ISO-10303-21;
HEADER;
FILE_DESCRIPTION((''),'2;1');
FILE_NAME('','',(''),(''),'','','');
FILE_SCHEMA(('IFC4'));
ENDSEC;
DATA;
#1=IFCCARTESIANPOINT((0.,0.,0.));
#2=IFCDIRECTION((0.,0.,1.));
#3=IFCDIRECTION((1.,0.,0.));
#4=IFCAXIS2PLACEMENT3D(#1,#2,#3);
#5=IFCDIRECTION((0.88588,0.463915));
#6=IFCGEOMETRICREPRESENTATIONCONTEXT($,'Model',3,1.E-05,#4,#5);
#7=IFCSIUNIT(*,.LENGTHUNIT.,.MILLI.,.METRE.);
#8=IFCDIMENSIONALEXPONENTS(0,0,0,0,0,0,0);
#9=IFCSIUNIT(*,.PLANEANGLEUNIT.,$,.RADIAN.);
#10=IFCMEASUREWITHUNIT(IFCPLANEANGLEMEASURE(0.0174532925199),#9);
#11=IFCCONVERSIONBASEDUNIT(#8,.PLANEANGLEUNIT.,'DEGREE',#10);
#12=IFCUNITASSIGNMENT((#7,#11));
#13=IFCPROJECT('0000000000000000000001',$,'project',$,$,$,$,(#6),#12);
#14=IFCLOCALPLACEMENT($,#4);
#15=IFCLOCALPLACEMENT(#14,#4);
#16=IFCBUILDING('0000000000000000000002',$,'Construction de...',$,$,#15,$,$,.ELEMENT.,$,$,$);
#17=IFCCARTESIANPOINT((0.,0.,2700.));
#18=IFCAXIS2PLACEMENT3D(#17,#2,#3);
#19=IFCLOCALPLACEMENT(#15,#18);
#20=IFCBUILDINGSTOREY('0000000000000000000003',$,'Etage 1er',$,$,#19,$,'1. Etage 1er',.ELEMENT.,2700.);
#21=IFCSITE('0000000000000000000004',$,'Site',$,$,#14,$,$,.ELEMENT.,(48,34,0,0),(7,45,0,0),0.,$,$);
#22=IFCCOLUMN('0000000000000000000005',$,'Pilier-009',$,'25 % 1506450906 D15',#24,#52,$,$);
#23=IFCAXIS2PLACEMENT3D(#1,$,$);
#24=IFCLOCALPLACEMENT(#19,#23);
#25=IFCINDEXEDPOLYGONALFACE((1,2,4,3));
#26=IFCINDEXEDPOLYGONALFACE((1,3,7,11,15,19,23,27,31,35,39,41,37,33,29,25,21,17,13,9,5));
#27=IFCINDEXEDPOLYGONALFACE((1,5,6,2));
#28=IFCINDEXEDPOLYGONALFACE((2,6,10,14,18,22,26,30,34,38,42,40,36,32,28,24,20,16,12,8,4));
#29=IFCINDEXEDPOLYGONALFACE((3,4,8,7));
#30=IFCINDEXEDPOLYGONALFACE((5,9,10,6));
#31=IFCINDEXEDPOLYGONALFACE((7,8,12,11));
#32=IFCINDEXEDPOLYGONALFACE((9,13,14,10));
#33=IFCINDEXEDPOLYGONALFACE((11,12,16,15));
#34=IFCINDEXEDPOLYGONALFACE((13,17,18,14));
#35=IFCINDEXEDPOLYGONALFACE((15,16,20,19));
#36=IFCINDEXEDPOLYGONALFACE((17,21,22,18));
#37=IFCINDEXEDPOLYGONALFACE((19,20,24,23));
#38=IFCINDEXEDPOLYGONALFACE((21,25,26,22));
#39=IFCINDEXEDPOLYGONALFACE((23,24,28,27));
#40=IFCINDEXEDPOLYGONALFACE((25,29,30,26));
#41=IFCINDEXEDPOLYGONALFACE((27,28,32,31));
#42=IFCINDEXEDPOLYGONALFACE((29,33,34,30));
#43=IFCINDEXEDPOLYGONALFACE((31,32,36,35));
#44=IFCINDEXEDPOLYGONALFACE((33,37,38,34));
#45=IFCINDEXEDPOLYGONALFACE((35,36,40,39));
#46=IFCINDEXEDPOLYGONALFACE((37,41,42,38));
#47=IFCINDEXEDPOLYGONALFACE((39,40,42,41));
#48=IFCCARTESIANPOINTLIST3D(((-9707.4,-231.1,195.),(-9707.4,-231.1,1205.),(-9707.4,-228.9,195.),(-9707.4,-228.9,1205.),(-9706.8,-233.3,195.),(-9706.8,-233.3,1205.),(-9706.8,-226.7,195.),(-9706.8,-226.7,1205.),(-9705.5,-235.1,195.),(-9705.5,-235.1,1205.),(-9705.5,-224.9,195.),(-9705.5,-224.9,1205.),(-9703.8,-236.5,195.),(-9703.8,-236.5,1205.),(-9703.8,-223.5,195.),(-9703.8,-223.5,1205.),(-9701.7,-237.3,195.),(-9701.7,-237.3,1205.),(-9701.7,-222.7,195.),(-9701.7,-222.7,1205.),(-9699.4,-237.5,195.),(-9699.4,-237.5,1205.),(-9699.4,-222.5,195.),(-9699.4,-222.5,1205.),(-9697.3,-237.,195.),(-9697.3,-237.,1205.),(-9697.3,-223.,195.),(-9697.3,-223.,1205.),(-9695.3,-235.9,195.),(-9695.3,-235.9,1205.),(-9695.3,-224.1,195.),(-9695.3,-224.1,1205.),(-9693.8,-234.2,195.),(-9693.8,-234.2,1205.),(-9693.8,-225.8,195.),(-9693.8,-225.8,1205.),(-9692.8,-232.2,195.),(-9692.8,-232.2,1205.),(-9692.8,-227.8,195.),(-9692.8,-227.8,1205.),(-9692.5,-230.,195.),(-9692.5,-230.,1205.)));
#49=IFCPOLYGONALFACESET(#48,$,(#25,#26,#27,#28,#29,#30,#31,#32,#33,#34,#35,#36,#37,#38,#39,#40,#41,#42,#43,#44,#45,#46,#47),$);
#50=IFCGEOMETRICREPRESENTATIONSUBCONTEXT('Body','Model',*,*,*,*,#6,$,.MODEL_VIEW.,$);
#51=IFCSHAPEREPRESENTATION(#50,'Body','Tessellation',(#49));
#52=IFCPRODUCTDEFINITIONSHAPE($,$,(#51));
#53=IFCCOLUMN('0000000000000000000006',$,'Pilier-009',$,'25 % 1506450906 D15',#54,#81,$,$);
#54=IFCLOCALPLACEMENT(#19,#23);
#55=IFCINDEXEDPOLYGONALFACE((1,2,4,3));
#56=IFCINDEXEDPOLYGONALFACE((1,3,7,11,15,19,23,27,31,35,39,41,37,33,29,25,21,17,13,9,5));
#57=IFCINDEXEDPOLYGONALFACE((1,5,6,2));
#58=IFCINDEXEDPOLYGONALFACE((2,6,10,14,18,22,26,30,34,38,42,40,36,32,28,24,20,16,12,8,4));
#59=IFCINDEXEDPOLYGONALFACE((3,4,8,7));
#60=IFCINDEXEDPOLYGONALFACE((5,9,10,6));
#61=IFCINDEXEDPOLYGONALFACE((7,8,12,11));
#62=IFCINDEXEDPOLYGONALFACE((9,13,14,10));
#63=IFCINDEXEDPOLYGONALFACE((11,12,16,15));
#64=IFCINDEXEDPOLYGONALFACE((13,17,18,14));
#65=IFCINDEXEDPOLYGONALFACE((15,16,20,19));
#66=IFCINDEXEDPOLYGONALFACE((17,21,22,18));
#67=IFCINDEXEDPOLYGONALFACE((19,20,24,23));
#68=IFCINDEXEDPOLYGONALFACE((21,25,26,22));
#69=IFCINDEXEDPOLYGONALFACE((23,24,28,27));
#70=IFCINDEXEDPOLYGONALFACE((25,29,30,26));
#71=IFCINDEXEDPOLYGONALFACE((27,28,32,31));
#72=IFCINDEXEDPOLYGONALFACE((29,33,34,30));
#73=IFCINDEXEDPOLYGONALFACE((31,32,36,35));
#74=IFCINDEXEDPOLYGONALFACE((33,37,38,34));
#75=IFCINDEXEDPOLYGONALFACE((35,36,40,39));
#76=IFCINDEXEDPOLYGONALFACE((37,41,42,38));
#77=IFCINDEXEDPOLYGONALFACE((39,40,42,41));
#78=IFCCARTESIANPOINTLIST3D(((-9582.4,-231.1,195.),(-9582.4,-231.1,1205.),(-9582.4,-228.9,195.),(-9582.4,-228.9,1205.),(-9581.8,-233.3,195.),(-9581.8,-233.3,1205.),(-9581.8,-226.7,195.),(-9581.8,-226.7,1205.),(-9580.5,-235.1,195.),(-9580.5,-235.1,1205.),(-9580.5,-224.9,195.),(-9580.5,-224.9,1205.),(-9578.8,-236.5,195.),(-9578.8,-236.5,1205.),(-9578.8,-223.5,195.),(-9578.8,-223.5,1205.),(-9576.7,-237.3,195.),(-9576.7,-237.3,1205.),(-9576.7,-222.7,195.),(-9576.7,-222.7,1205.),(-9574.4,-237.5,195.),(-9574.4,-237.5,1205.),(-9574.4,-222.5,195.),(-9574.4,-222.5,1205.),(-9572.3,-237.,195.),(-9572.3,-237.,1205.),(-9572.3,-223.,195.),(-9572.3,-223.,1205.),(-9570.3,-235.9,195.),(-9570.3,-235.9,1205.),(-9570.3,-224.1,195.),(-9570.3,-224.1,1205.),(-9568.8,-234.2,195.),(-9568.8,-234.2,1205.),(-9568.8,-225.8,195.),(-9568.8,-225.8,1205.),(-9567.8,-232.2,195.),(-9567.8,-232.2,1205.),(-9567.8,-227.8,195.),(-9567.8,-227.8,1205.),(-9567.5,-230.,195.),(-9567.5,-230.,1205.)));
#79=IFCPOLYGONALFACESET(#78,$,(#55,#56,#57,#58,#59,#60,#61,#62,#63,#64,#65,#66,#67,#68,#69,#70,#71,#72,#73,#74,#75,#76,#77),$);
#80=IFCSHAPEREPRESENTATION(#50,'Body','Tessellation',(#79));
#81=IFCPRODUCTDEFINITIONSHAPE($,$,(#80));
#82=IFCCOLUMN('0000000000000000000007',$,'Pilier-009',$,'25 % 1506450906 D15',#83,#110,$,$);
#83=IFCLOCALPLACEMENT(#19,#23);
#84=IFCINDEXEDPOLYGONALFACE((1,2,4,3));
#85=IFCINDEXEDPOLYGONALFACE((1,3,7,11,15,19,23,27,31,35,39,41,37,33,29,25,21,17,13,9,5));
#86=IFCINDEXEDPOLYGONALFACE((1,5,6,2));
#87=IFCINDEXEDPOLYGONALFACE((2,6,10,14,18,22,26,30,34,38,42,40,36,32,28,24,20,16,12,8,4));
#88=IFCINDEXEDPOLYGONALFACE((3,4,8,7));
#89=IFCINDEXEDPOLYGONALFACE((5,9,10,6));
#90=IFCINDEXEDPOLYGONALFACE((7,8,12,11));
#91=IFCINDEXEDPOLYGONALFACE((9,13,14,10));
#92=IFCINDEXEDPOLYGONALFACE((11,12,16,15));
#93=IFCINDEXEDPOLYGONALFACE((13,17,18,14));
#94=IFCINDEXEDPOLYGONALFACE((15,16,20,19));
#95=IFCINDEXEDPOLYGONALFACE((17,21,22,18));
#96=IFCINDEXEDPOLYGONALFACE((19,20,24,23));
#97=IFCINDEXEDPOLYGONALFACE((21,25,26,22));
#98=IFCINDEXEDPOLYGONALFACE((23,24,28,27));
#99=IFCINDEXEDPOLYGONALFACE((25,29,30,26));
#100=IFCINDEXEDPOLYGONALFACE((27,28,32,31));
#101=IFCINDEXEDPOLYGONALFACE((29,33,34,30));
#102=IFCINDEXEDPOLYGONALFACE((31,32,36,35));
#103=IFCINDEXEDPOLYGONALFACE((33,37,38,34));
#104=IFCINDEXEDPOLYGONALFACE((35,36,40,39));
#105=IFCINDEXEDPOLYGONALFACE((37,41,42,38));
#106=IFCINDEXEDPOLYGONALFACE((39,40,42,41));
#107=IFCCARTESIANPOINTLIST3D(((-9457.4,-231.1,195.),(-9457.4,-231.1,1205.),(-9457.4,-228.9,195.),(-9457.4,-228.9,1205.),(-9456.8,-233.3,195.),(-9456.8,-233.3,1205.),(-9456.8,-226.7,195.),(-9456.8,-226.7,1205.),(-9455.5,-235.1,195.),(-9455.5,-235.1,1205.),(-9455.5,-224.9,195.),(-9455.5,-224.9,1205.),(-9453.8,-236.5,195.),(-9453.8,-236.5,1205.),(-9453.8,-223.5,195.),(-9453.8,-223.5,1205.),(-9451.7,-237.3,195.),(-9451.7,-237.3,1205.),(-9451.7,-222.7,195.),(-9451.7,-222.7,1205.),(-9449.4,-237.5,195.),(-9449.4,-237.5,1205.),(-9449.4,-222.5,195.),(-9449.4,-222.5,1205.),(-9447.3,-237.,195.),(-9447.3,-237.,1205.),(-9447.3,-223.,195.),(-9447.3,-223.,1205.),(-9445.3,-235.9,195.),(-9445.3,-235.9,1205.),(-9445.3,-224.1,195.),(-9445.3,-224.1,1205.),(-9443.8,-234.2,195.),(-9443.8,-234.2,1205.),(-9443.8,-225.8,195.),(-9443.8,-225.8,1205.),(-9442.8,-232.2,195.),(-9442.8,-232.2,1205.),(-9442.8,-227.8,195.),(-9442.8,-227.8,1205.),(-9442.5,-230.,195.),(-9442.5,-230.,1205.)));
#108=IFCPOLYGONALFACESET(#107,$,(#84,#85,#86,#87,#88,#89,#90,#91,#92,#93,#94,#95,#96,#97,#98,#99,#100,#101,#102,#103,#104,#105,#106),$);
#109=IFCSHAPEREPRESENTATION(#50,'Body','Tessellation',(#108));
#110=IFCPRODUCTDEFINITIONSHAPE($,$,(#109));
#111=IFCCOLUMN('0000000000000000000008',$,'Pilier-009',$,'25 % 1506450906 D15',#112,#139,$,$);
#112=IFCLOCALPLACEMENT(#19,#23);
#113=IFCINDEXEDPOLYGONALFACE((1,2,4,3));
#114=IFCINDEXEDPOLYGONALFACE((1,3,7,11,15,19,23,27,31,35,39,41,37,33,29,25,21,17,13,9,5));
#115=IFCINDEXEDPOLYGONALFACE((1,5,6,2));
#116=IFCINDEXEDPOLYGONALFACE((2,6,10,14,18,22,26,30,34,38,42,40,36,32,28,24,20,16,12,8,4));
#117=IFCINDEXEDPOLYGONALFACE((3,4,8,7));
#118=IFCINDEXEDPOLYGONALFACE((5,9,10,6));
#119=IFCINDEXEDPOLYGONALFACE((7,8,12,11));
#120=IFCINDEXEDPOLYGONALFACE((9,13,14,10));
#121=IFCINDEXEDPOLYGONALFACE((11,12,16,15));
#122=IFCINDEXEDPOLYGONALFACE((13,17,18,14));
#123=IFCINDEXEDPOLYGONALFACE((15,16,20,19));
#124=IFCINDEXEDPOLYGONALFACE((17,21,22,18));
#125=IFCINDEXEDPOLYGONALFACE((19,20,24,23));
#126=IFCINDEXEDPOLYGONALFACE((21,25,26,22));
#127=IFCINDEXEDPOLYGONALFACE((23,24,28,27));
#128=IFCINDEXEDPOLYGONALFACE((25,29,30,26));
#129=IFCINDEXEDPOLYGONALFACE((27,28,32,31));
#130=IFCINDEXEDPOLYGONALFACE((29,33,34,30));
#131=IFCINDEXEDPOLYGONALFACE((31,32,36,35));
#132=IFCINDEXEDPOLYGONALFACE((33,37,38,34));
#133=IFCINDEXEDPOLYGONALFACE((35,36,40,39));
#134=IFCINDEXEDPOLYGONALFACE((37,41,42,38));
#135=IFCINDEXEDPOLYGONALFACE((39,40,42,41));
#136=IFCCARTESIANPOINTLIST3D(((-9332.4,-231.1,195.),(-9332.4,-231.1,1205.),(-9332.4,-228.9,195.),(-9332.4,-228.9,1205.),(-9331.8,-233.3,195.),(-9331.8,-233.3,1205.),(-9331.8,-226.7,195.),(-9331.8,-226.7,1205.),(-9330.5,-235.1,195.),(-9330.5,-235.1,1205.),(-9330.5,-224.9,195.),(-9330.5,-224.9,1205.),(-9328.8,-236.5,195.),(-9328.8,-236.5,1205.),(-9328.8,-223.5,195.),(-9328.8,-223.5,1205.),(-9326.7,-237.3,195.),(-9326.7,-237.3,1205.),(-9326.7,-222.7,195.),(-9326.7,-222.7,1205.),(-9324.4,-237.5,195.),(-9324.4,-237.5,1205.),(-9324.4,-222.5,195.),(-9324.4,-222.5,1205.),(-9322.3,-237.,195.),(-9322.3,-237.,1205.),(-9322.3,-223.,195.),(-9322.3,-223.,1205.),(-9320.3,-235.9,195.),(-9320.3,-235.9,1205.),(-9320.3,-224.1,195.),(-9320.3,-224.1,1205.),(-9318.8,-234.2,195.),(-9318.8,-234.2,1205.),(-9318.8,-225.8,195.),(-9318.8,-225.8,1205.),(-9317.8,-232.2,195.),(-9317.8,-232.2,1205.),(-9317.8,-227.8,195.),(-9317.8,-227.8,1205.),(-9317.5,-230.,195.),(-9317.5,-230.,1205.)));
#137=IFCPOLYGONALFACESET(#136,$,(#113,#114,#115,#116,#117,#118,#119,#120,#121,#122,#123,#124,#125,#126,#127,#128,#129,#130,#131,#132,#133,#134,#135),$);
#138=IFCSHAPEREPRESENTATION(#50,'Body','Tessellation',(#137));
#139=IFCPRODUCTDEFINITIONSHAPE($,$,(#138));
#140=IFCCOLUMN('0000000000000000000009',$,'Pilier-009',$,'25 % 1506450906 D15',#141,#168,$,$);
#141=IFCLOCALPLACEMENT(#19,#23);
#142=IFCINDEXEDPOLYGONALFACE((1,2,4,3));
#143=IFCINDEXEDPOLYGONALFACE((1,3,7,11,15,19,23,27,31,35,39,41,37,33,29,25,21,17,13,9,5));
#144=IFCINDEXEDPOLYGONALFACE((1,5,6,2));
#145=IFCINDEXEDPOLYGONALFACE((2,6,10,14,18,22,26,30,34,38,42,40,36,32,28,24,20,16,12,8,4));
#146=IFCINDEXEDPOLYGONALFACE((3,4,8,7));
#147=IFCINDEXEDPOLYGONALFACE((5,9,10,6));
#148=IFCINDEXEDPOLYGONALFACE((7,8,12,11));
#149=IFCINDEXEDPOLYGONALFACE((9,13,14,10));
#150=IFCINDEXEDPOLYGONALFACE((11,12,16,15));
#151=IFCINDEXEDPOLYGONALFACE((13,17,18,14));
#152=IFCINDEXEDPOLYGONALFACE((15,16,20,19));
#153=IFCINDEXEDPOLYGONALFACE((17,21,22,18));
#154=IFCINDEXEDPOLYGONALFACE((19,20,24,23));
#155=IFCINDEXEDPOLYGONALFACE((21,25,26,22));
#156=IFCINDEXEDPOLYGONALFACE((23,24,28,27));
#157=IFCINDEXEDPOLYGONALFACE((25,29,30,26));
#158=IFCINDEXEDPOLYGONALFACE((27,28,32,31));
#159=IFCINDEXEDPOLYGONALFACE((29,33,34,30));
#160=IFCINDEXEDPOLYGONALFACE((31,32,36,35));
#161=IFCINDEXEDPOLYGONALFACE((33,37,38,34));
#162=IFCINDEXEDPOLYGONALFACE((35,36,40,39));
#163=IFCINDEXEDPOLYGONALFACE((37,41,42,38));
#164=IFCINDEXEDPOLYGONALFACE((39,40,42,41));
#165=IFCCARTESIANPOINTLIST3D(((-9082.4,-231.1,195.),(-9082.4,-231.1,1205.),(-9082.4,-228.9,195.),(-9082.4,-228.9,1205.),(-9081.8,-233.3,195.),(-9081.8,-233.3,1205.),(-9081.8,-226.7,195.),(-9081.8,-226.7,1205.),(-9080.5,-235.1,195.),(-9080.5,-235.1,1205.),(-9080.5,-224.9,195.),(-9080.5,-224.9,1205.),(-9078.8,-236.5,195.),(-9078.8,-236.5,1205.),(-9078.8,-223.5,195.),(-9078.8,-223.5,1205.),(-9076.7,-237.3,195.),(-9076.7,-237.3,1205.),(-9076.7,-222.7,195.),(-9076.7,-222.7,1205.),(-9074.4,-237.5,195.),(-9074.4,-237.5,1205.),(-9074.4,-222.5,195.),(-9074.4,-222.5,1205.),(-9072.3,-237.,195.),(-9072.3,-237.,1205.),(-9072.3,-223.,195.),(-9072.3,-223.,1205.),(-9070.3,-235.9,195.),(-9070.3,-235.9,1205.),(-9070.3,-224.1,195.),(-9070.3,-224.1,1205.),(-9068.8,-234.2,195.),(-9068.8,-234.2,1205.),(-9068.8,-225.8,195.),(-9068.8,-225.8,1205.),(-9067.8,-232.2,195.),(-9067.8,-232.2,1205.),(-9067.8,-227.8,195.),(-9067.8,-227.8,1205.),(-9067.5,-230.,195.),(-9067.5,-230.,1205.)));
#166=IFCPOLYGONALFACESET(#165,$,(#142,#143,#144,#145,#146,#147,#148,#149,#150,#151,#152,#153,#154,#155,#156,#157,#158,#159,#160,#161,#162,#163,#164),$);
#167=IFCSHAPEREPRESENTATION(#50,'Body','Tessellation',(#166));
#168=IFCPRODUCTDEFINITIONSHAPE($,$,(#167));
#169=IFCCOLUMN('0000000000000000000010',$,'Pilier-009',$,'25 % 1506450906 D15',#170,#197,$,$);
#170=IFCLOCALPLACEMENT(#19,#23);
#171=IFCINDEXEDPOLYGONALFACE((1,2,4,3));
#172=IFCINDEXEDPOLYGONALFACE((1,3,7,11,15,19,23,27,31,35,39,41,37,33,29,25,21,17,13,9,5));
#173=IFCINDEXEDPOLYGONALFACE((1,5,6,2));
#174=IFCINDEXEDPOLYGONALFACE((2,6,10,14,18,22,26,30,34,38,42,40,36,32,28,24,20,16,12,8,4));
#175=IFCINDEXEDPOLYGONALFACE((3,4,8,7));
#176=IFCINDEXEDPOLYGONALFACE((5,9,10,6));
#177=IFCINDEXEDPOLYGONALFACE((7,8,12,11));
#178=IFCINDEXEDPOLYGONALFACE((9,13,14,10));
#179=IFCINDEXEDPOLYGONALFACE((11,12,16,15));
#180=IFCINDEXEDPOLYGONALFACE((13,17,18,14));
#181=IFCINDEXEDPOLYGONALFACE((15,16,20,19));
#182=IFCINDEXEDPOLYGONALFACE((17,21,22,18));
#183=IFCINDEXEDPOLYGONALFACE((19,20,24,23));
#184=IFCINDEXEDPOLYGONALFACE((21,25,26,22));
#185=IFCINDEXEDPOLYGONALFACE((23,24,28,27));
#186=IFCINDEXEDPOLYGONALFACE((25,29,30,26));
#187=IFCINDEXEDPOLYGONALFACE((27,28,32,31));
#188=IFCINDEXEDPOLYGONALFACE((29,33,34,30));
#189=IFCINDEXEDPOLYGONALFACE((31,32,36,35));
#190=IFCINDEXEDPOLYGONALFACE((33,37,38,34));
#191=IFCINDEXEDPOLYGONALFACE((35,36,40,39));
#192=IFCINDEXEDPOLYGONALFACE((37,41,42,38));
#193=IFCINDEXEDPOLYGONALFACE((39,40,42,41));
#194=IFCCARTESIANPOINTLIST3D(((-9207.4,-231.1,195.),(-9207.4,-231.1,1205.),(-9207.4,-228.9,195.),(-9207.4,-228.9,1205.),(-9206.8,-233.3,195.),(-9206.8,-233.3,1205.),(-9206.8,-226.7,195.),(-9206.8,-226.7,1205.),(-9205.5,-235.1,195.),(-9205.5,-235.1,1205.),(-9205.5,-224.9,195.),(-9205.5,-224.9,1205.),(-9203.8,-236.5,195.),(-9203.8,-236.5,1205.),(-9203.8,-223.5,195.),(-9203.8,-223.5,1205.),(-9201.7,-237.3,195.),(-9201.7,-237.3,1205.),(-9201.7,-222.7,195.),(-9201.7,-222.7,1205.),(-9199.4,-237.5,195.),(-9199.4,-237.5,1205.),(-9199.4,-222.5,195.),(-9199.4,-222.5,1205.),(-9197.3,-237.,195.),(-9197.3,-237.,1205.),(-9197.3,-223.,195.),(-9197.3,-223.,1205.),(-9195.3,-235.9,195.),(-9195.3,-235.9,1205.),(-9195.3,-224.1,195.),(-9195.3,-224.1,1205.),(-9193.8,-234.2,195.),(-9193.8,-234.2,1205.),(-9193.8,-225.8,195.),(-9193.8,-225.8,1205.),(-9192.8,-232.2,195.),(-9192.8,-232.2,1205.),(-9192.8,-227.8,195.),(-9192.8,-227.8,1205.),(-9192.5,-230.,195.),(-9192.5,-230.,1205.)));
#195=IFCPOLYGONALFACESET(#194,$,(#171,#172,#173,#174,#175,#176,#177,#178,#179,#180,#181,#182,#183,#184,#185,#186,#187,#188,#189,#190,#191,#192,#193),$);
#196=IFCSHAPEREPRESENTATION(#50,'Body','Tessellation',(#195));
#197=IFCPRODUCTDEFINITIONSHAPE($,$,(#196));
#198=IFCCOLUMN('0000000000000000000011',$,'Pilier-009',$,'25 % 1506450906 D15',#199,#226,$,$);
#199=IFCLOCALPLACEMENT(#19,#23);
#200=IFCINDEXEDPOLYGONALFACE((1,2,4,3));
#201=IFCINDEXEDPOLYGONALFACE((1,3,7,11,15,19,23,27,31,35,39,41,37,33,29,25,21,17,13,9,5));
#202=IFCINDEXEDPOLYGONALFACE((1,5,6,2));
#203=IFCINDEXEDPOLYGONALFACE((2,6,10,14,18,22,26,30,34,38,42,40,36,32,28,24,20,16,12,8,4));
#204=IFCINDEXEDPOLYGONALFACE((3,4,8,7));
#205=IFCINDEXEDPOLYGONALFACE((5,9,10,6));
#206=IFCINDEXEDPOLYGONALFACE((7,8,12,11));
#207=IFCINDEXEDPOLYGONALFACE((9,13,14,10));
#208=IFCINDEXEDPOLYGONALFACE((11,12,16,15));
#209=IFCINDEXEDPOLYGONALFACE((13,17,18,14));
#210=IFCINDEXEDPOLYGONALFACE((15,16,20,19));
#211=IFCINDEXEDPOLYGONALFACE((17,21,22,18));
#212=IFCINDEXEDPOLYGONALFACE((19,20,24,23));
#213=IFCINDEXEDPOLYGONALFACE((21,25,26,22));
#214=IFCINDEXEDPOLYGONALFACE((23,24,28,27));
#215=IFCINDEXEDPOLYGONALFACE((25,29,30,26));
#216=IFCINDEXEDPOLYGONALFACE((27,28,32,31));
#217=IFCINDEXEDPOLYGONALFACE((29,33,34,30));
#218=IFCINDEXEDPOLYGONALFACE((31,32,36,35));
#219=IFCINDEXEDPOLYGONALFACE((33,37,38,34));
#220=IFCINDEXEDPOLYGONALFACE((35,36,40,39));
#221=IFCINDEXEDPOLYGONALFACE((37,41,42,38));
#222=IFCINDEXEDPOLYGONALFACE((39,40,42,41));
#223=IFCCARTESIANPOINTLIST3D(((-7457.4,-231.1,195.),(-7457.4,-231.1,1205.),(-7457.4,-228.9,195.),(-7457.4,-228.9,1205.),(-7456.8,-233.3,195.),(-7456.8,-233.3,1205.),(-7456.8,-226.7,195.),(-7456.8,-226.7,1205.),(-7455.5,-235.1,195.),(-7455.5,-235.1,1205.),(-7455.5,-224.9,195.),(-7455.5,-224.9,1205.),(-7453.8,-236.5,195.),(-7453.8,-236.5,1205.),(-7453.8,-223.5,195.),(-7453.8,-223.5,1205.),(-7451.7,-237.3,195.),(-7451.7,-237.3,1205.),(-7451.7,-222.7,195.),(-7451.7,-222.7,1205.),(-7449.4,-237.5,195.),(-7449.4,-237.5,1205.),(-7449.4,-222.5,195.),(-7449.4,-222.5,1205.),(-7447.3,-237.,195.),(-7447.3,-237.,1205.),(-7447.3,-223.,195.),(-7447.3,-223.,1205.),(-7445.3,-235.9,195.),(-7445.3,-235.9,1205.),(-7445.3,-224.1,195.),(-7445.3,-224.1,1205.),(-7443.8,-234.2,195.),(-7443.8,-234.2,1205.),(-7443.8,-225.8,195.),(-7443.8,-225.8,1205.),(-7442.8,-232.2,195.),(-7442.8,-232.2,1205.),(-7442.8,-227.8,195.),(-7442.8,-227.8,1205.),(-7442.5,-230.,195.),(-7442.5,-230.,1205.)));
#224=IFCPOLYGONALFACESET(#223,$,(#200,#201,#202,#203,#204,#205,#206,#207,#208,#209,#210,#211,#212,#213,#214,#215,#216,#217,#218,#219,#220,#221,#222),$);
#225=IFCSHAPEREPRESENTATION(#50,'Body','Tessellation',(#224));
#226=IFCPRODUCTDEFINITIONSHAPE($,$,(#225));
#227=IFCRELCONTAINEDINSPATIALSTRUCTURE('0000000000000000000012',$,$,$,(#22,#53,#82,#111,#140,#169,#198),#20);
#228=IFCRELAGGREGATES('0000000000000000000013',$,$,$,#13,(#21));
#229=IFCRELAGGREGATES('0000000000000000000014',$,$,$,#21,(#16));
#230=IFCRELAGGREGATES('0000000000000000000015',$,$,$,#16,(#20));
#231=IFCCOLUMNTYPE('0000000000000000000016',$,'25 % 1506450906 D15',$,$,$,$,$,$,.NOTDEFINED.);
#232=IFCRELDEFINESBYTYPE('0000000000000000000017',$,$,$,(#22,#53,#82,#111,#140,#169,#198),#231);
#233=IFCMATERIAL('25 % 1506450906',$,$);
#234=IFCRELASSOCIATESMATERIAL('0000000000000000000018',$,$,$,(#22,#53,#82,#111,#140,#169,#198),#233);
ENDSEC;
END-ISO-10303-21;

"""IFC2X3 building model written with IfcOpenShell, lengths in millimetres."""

from ifc_helpers import new_model, entity, si_unit, converted_unit, direction, frame, origin_with_axes, origin_2d_with_axis, place, context, subcontext, project, spatial, circle, extrude, material, type_object, element, save


model = new_model("IFC2X3")

# Units and contexts
model_context = context("Model", 3, precision=1e-05, world=origin_with_axes(), true_north=direction((0.88588, 0.463915)))
body_context = subcontext(model_context, "Body", "Model", "MODEL_VIEW")
ifc_project = project(units=[si_unit("LENGTHUNIT", "METRE", prefix="MILLI"), converted_unit("PLANEANGLEUNIT", "DEGREE", entity("IfcPlaneAngleMeasure", 0.0174532925199), si_unit("PLANEANGLEUNIT", "RADIAN"), dimensions=[0, 0, 0, 0, 0, 0, 0])], contexts=[model_context])

# Site, building, storey
site_placement = place(None, origin_with_axes())
site = spatial("IfcSite", under=ifc_project, at=site_placement, Name="Site", CompositionType="ELEMENT", RefLatitude=(48, 34, 0, 0), RefLongitude=(7, 45, 0, 0), RefElevation=0.0)
building_placement = place(site_placement, origin_with_axes())
building = spatial("IfcBuilding", under=site, at=building_placement, Name="Construction de...", CompositionType="ELEMENT")
storey_placement = place(building_placement, frame((0.0, 0.0, 2700.0), z_axis=(0.0, 0.0, 1.0), x_axis=(1.0, 0.0, 0.0)))
storey = spatial("IfcBuildingStorey", under=building, at=storey_placement, Name="Etage 1er", LongName="1. Etage 1er", CompositionType="ELEMENT", Elevation=2700.0)

# Columns
ifc_material = material(Name="25 % 1506450906")
column_type = type_object("IfcColumnType", Name="25 % 1506450906 D15", PredefinedType="NOTDEFINED")
for number, where, z_axis, x_axis, name in (
    (1, (-9700.0, -230.0, 195.0), (0.0, 0.0, 1.0), (1.0, 0.0, 0.0), "Pilier-009"),
    (2, (-9575.0, -230.0, 195.0), (0.0, 0.0, 1.0), (1.0, 0.0, 0.0), "Pilier-009"),
    (3, (-9450.0, -230.0, 195.0), (0.0, 0.0, 1.0), (1.0, 0.0, 0.0), "Pilier-009"),
    (4, (-9325.0, -230.0, 195.0), (0.0, 0.0, 1.0), (1.0, 0.0, 0.0), "Pilier-009"),
    (5, (-9075.0, -230.0, 195.0), (0.0, 0.0, 1.0), (1.0, 0.0, 0.0), "Pilier-009"),
    (6, (-9200.0, -230.0, 195.0), (0.0, 0.0, 1.0), (1.0, 0.0, 0.0), "Pilier-009"),
    (7, (-7450.0, -230.0, 195.0), (0.0, 0.0, 1.0), (1.0, 0.0, 0.0), "Pilier-009"),
):
    element("IfcColumn", number, at=place(storey_placement, frame(where, z_axis=z_axis, x_axis=x_axis)), inside=storey, type_object=column_type, material=ifc_material, Name=name, ObjectType="25 % 1506450906 D15", context=body_context, shape_type="SweptSolid", body=[
        extrude(circle(Radius=7.5, at=origin_2d_with_axis()), origin_with_axes(), (0.0, 0.0, 1.0), 1010.0),
    ])

save(model, "model.ifc")
